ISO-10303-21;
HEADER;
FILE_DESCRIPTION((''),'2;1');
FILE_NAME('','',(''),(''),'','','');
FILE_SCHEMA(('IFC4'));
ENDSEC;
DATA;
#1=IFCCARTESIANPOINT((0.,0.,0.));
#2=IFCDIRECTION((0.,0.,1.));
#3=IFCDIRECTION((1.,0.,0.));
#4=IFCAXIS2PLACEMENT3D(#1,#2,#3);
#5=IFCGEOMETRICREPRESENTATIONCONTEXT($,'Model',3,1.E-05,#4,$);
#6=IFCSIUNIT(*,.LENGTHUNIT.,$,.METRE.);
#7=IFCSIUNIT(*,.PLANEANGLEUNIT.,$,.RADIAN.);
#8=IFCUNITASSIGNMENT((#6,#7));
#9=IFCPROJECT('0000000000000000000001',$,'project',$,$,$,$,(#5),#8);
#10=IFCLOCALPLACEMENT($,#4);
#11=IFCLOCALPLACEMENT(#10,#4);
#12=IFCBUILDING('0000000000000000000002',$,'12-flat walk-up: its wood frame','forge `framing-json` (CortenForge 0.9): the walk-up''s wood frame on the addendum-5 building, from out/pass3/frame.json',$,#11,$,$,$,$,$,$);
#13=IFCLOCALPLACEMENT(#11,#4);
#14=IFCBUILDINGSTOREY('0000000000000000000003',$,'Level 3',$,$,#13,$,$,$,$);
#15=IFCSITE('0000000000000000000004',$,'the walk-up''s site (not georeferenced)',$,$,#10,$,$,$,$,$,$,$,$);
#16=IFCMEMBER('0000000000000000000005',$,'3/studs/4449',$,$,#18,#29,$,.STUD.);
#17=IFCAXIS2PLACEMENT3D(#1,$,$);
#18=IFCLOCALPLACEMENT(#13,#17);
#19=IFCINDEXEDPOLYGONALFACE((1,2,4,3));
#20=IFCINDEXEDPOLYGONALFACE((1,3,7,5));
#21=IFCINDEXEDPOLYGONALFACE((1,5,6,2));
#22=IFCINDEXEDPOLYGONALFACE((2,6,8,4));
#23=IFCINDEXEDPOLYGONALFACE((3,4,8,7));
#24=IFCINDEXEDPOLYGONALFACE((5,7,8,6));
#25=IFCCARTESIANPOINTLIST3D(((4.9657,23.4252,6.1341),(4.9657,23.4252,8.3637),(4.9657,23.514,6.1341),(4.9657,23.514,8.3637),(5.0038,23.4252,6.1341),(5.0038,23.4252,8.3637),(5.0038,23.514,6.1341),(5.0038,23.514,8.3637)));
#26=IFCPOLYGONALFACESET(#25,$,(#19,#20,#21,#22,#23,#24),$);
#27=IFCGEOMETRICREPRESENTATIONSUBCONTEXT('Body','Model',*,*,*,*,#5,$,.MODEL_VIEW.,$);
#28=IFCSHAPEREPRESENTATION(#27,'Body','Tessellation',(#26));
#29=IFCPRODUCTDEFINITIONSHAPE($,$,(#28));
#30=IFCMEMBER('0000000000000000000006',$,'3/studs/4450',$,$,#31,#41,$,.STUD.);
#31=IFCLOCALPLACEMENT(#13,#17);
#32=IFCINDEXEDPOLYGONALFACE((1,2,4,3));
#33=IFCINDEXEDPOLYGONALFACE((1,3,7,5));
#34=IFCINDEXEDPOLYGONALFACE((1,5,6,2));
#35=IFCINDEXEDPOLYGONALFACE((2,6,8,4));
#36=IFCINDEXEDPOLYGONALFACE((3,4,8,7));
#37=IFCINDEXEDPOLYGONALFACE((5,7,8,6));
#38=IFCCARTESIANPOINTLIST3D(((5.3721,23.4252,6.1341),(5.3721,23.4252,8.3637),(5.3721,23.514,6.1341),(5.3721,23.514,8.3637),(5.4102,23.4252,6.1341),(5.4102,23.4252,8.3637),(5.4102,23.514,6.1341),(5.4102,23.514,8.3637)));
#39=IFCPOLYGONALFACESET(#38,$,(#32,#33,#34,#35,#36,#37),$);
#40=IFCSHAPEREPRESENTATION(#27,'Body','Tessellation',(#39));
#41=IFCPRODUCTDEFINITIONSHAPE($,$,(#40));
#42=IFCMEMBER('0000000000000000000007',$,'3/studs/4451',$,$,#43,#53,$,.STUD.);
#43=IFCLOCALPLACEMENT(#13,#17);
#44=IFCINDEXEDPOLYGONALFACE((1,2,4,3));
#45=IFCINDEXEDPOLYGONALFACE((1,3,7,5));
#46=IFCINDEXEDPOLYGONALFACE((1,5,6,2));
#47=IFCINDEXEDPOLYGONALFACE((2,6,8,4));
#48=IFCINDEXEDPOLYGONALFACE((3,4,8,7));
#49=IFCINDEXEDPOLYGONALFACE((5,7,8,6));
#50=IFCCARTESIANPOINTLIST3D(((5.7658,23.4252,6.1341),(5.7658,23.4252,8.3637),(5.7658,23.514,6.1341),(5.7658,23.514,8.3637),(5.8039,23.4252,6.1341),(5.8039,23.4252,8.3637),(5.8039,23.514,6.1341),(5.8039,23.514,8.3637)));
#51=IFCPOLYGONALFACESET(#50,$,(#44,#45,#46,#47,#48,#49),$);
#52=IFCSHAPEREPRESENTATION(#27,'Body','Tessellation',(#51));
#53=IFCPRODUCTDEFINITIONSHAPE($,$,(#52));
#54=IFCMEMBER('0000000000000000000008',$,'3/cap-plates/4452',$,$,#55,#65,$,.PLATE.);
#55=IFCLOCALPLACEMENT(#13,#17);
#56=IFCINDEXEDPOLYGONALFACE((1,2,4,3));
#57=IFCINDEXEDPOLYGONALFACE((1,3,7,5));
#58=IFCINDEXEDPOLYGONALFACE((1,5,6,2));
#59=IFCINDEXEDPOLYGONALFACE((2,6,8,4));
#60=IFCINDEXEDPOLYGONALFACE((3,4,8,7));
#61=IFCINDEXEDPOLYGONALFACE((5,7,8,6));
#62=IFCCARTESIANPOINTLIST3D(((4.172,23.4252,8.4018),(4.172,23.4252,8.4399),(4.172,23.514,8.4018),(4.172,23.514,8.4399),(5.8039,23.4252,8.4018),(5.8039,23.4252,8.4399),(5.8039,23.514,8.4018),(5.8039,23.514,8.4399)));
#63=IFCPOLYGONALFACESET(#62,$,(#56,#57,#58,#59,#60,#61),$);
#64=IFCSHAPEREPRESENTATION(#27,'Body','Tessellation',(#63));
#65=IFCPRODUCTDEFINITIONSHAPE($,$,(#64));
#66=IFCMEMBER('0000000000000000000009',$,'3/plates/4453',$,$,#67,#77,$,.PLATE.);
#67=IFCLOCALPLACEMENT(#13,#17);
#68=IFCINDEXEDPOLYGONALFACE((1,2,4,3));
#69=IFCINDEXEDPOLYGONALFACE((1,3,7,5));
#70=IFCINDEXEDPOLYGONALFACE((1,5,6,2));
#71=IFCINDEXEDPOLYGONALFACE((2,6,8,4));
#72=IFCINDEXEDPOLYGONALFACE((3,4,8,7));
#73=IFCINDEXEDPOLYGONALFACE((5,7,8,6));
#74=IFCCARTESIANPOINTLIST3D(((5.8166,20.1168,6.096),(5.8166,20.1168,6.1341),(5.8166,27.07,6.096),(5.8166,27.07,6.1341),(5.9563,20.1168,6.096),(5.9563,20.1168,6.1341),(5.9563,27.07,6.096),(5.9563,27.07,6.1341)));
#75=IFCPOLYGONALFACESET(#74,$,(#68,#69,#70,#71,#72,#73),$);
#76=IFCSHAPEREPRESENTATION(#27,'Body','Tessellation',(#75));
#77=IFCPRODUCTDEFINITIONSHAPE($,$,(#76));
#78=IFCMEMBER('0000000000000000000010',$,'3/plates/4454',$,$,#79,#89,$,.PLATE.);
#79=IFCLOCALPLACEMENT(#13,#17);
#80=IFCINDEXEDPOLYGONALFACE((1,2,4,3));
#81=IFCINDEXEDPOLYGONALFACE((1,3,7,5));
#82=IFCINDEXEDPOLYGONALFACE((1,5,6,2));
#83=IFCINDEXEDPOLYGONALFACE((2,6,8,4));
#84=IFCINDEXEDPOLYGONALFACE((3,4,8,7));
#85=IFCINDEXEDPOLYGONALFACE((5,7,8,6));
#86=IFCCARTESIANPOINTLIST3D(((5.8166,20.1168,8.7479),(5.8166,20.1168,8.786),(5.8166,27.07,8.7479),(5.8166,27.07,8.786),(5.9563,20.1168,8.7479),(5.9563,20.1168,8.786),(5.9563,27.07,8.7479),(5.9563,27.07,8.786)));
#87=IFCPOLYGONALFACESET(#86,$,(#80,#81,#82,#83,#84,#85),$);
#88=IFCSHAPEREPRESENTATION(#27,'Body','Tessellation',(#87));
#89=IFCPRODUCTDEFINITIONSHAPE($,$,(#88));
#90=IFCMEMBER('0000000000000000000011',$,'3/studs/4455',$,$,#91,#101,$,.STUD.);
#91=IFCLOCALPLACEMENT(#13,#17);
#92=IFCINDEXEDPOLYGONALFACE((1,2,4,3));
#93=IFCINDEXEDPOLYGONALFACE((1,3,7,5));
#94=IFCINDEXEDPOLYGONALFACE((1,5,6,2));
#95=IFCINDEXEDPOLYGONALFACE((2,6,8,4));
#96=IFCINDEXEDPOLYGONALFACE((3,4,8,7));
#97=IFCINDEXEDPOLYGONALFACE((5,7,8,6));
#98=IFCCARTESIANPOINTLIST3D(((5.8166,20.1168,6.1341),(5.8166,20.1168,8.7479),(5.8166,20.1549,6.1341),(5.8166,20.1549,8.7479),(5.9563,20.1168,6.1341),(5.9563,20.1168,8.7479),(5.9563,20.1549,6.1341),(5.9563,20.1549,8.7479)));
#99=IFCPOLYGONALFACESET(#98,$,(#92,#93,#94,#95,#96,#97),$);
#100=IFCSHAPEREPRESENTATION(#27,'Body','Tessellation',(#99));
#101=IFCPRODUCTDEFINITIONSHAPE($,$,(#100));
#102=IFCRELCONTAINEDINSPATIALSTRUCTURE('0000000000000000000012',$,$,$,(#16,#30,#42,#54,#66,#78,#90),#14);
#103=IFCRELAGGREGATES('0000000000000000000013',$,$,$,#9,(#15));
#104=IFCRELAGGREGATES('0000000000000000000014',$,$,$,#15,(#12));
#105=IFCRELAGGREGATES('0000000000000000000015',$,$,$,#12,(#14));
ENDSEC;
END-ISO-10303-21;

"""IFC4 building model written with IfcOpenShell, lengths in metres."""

from ifc_helpers import new_model, si_unit, frame, frame_2d, origin, origin_with_axes, place, context, subcontext, project, spatial, rectangle, extrude, element, save


model = new_model("IFC4")

# Units and contexts
model_context = context("Model", 3, precision=1e-05, world=origin_with_axes())
body_context = subcontext(model_context, "Body", "Model", "MODEL_VIEW")
ifc_project = project(units=[si_unit("LENGTHUNIT", "METRE"), si_unit("PLANEANGLEUNIT", "RADIAN")], contexts=[model_context])

# Site, building, storey
site_placement = place(None, origin_with_axes())
site = spatial("IfcSite", under=ifc_project, at=site_placement, Name="the walk-up's site (not georeferenced)")
building_placement = place(site_placement, origin_with_axes())
building = spatial("IfcBuilding", under=site, at=building_placement, Name="12-flat walk-up: its wood frame", Description="forge `framing-json` (CortenForge 0.9): the walk-up's wood frame on the addendum-5 building, from out/pass3/frame.json")
storey_placement = place(building_placement, origin_with_axes())
storey = spatial("IfcBuildingStorey", under=building, at=storey_placement, Name="Level 3")

# Members
for number, where, z_axis, x_axis, name in (
    (1, (4.9657, 23.4251, 6.1341), (0.0, 0.0, 1.0), (1.0, 0.0, 0.0), "3/studs/4449"),
    (2, (5.3721, 23.4251, 6.1341), (0.0, 0.0, 1.0), (1.0, 0.0, 0.0), "3/studs/4450"),
    (3, (5.7658, 23.4251, 6.1341), (0.0, 0.0, 1.0), (1.0, 0.0, 0.0), "3/studs/4451"),
):
    element("IfcMember", number, at=place(storey_placement, frame(where, z_axis=z_axis, x_axis=x_axis)), inside=storey, Name=name, PredefinedType="STUD", context=body_context, shape_type="SweptSolid", body=[
        extrude(rectangle(XDim=0.0381, YDim=0.0889, at=frame_2d((0.0191, 0.0445))), origin(), (0.0, 0.0, 1.0), 2.2296),
    ])
member_1_placement = place(storey_placement, frame((4.1719, 23.4251, 8.4018), z_axis=(0.0, 0.0, 1.0), x_axis=(1.0, 0.0, 0.0)))
element("IfcMember", 4, at=member_1_placement, inside=storey, Name="3/cap-plates/4452", PredefinedType="PLATE", context=body_context, shape_type="SweptSolid", body=[
    extrude(rectangle(XDim=1.6319, YDim=0.0889, at=frame_2d((0.816, 0.0445))), origin(), (0.0, 0.0, 1.0), 0.0381),
])
for number, where, z_axis, x_axis, name in (
    (5, (5.8166, 20.1168, 6.096), (0.0, 0.0, 1.0), (1.0, 0.0, 0.0), "3/plates/4453"),
    (6, (5.8166, 20.1168, 8.7479), (0.0, 0.0, 1.0), (1.0, 0.0, 0.0), "3/plates/4454"),
):
    element("IfcMember", number, at=place(storey_placement, frame(where, z_axis=z_axis, x_axis=x_axis)), inside=storey, Name=name, PredefinedType="PLATE", context=body_context, shape_type="SweptSolid", body=[
        extrude(rectangle(XDim=0.1397, YDim=6.9532, at=frame_2d((0.0698, 3.4766))), origin(), (0.0, 0.0, 1.0), 0.0381),
    ])
member_2_placement = place(storey_placement, frame((5.8166, 20.1168, 6.1341), z_axis=(0.0, 0.0, 1.0), x_axis=(1.0, 0.0, 0.0)))
element("IfcMember", 7, at=member_2_placement, inside=storey, Name="3/studs/4455", PredefinedType="STUD", context=body_context, shape_type="SweptSolid", body=[
    extrude(rectangle(XDim=0.1397, YDim=0.0381, at=frame_2d((0.0698, 0.0191))), origin(), (0.0, 0.0, 1.0), 2.6138),
])

save(model, "model.ifc")
